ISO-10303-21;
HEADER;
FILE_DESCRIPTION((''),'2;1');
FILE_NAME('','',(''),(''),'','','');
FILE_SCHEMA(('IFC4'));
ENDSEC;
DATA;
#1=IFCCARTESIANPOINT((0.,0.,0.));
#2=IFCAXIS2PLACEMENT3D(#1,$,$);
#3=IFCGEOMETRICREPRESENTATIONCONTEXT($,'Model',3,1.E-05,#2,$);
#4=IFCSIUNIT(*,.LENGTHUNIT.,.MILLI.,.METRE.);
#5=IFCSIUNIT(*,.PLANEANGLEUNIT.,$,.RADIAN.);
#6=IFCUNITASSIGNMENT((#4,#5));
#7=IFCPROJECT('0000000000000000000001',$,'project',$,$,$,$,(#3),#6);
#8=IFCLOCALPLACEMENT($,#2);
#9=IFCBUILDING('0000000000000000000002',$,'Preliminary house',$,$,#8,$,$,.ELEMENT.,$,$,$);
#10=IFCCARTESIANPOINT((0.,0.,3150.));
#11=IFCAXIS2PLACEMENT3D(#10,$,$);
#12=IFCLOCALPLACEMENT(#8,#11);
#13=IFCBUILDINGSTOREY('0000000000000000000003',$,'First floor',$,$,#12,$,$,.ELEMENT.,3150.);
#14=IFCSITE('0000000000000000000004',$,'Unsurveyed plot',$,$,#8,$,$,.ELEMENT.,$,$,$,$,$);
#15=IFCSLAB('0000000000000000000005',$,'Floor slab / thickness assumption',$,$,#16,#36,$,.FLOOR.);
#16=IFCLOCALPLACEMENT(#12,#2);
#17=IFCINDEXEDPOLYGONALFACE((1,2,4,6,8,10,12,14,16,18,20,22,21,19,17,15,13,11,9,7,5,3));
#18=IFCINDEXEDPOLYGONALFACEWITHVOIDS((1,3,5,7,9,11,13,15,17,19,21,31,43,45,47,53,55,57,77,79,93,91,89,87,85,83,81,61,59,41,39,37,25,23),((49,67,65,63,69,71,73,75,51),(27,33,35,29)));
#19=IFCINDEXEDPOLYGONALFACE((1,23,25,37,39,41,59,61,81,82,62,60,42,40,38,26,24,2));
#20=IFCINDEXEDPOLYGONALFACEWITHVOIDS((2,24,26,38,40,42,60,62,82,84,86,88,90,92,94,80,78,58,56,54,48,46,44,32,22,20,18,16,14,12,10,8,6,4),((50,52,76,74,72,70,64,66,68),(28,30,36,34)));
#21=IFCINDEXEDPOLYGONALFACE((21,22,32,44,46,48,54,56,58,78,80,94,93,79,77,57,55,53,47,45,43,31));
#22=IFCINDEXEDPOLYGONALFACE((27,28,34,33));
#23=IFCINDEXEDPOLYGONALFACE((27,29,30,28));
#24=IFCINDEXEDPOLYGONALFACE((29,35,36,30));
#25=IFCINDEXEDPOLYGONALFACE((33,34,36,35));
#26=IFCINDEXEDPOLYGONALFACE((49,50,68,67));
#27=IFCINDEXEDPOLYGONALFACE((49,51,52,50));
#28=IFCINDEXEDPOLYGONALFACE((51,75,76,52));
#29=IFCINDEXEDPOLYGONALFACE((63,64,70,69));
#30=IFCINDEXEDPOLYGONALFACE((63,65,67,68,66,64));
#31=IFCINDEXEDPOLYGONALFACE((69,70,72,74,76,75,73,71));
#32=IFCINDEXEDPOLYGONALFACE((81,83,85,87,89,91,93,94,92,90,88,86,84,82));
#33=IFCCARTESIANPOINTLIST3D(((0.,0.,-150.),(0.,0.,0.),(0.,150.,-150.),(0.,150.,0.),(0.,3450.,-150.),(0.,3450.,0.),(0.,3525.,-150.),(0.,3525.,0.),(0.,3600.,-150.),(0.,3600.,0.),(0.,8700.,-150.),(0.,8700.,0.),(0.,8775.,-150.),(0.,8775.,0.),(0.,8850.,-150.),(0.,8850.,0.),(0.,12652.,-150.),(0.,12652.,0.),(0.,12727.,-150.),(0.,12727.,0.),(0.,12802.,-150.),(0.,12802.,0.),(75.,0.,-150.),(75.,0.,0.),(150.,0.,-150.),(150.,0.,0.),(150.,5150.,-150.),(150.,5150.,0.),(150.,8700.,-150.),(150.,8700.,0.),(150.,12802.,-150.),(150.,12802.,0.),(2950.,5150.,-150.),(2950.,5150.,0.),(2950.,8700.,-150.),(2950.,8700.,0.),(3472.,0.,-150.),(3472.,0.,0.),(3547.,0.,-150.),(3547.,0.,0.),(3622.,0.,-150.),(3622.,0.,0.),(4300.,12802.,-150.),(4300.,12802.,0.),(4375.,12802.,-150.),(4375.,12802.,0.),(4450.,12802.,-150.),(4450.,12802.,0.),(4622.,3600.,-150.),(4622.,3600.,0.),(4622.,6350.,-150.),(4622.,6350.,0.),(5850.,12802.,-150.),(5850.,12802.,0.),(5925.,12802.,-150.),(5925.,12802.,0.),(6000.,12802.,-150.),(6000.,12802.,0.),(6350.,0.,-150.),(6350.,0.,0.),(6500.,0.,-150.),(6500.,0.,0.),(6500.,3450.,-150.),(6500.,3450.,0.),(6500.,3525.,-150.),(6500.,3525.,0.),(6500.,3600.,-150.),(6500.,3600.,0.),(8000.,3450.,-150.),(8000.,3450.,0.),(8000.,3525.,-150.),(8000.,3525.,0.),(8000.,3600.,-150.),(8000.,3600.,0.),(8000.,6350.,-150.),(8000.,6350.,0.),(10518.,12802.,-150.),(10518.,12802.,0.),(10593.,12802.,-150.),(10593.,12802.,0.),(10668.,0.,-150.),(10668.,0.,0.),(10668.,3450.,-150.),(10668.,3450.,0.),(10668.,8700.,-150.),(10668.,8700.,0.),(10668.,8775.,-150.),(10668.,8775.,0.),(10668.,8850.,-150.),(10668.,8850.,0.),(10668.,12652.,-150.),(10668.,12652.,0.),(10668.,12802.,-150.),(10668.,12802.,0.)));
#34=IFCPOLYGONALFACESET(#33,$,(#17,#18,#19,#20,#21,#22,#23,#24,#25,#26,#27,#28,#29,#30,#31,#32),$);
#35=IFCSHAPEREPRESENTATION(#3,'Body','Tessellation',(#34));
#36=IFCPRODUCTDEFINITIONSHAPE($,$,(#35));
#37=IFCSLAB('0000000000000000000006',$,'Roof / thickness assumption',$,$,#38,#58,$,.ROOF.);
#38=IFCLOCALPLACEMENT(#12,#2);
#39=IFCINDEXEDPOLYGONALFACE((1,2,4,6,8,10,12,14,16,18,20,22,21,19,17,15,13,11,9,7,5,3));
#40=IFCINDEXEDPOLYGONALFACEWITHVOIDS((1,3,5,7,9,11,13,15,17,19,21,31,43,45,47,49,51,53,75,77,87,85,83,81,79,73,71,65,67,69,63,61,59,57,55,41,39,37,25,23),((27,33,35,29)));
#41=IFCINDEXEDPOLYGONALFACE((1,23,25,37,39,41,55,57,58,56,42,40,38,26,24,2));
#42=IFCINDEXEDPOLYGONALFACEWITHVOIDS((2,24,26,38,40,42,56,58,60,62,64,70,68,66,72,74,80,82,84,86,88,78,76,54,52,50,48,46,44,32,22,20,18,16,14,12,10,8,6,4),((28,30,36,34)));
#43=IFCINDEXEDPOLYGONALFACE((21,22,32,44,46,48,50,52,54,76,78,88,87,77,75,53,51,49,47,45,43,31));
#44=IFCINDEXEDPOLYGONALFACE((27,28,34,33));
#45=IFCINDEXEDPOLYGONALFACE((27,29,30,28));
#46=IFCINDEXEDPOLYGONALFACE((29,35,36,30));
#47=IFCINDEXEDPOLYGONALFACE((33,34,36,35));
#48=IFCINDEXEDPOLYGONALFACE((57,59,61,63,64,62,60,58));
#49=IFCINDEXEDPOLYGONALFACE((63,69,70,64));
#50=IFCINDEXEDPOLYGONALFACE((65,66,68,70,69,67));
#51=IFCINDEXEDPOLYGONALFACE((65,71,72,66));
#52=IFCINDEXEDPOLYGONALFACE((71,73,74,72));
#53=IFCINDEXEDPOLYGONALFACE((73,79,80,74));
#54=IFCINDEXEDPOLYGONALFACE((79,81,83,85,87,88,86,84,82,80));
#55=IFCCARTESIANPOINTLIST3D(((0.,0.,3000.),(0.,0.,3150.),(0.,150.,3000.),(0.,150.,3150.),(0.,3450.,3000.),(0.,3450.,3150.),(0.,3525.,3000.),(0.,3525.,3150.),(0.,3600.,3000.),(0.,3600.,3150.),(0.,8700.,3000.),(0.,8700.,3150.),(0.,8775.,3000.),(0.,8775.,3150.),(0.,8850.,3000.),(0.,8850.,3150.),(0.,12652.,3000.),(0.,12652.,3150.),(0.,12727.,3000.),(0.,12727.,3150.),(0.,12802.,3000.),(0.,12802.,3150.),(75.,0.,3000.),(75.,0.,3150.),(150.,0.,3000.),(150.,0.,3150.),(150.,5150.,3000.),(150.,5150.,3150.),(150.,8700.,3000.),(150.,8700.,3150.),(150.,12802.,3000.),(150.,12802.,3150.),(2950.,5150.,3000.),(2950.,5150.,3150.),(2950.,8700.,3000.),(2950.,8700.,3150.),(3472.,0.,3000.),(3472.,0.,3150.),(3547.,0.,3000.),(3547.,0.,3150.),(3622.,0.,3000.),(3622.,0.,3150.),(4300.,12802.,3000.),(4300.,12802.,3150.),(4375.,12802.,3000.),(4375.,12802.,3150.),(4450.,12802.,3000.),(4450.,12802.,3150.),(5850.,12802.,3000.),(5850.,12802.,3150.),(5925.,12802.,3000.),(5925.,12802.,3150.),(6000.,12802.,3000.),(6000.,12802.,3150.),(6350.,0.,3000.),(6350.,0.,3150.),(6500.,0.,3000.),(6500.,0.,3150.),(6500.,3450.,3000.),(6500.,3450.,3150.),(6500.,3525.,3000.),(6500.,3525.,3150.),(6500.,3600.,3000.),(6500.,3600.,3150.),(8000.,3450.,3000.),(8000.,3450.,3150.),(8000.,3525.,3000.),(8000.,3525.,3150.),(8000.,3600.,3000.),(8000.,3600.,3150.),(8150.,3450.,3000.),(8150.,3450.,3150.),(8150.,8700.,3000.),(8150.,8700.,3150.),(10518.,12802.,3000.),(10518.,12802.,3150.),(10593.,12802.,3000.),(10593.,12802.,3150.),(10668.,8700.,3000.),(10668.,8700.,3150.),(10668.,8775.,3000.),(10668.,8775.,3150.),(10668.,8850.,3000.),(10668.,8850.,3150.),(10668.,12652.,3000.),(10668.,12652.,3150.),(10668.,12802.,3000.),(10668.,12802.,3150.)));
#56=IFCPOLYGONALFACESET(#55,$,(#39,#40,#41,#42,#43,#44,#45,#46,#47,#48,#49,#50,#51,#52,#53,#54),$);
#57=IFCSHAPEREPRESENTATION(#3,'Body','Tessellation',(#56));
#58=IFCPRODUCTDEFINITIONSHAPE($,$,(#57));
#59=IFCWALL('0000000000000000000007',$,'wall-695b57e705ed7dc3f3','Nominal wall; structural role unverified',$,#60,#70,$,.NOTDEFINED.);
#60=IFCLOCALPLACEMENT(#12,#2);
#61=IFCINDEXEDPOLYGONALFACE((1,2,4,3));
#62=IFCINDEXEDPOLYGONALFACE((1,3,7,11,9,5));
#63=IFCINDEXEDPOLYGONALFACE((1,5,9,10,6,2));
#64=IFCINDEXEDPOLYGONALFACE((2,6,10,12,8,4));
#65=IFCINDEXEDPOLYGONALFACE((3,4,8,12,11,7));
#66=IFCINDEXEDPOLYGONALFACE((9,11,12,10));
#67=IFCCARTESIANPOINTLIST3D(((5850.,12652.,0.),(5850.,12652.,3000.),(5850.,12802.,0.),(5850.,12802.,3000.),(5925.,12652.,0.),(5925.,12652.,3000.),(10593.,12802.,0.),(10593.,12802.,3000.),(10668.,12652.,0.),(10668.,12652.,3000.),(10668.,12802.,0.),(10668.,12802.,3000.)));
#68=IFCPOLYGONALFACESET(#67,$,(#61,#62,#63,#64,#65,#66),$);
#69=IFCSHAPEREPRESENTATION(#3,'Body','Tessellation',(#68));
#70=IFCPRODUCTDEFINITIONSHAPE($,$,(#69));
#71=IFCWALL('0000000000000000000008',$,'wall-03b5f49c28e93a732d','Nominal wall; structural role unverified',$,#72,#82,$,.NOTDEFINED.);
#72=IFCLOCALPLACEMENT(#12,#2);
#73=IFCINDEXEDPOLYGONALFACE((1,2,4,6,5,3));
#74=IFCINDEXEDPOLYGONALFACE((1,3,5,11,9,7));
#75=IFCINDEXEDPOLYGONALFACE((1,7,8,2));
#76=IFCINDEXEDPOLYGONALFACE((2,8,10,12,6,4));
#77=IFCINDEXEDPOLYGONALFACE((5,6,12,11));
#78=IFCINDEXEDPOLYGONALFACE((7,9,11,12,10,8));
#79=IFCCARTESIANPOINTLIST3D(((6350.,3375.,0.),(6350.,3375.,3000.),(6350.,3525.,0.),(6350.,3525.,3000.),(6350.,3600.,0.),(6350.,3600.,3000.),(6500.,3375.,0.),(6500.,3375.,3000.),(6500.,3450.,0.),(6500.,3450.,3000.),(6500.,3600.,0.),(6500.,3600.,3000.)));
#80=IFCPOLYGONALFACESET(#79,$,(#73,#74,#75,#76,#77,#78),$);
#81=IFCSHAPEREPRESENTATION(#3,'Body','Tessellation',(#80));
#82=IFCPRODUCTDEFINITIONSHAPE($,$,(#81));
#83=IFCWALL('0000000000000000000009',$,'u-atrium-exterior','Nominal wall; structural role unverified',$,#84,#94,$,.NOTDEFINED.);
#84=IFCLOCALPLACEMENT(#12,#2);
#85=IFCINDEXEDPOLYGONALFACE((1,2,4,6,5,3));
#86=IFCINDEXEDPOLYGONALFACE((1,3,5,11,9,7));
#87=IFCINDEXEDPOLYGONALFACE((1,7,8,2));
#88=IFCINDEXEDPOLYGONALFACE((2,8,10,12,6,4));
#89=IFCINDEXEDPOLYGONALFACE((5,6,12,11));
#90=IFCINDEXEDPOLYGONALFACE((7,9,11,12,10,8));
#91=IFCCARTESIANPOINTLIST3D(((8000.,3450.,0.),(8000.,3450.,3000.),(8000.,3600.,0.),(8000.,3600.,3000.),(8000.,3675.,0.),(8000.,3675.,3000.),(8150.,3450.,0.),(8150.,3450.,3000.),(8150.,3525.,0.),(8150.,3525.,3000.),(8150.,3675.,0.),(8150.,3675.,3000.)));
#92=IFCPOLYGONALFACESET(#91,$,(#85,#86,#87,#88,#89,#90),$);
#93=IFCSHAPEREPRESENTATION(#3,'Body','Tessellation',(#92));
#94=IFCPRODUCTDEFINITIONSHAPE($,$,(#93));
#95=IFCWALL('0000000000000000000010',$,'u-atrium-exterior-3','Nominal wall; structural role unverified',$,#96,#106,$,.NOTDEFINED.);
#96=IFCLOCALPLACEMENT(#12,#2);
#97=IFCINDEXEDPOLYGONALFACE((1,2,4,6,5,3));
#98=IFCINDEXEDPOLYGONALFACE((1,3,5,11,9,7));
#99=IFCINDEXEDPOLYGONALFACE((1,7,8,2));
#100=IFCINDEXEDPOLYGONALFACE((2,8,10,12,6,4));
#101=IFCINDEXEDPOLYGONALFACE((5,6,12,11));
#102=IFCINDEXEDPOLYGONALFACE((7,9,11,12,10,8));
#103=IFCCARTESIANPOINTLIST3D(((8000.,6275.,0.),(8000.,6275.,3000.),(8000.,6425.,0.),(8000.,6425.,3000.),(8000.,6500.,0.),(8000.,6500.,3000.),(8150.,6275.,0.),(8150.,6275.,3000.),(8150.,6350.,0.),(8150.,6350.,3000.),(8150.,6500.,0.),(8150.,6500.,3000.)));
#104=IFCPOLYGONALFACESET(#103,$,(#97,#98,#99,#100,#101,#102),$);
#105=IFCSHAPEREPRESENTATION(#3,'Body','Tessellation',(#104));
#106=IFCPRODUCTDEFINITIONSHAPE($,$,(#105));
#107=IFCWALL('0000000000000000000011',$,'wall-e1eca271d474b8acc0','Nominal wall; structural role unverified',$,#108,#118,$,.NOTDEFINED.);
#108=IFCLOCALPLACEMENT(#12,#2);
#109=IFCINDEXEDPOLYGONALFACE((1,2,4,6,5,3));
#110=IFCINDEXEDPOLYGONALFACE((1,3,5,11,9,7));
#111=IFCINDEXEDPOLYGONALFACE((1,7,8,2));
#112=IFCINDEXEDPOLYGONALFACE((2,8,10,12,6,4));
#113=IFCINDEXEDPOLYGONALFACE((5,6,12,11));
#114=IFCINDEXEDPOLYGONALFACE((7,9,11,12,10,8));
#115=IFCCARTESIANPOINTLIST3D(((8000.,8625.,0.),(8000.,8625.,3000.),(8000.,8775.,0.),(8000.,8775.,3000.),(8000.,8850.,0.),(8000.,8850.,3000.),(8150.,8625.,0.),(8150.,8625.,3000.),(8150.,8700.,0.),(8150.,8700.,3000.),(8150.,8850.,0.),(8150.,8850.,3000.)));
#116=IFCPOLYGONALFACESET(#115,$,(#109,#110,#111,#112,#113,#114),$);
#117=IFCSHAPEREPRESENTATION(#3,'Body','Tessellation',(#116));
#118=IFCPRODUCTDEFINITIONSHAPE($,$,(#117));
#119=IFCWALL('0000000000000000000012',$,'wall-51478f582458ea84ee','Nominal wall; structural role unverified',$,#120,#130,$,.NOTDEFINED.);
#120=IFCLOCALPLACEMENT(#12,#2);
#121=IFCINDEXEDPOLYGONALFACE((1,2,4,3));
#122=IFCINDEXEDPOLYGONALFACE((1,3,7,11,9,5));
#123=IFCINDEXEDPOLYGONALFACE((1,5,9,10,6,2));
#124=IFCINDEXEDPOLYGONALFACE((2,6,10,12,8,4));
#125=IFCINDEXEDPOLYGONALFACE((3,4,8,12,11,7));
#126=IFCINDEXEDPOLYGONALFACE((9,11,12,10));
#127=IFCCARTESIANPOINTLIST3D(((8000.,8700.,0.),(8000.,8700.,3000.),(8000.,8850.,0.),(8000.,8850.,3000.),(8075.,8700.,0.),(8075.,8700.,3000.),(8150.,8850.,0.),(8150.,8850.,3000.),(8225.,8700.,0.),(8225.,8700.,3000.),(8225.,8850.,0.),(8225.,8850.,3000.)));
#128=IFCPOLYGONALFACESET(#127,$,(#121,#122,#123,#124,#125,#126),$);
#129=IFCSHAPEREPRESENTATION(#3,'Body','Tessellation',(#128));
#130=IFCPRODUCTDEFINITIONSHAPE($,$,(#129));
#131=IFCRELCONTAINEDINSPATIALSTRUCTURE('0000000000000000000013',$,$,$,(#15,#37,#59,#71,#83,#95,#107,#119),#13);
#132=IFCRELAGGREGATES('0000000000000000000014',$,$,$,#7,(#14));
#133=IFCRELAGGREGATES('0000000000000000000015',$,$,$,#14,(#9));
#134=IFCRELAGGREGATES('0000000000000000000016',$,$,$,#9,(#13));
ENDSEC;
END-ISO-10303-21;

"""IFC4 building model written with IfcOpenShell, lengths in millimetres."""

from ifc_helpers import new_model, si_unit, frame, origin, place, context, project, spatial, polyline, outline, extrude, element, save


model = new_model("IFC4")

# Units and contexts
model_context = context("Model", 3, precision=1e-05, world=origin())
ifc_project = project(units=[si_unit("LENGTHUNIT", "METRE", prefix="MILLI"), si_unit("PLANEANGLEUNIT", "RADIAN")], contexts=[model_context])

# Site, building, storey
placement_1 = place(None, origin())
site = spatial("IfcSite", under=ifc_project, at=placement_1, Name="Unsurveyed plot", CompositionType="ELEMENT")
building = spatial("IfcBuilding", under=site, at=placement_1, Name="Preliminary house", CompositionType="ELEMENT")
placement_2 = place(placement_1, frame((0.0, 0.0, 3150.0)))
storey = spatial("IfcBuildingStorey", under=building, at=placement_2, Name="First floor", CompositionType="ELEMENT", Elevation=3150.0)

# Slabs
element("IfcSlab", 1, at=placement_2, inside=storey, Name="Floor slab / thickness assumption", PredefinedType="FLOOR", context=model_context, shape_type="SweptSolid", body=[
    extrude(outline(polyline([(75.0, 0.0), (0.0, 0.0), (0.0, 150.0), (0.0, 3450.0), (0.0, 3525.0), (0.0, 3600.0), (0.0, 8700.0), (0.0, 8775.0), (0.0, 8850.0), (0.0, 12652.0), (0.0, 12727.0), (0.0, 12802.0), (150.0, 12802.0), (4300.0, 12802.0), (4375.0, 12802.0), (4450.0, 12802.0), (5850.0, 12802.0), (5925.0, 12802.0), (6000.0, 12802.0), (10518.0, 12802.0), (10593.0, 12802.0), (10668.0, 12802.0), (10668.0, 12652.0), (10668.0, 8850.0), (10668.0, 8775.0), (10668.0, 8700.0), (10668.0, 3450.0), (10668.0, 0.0), (6500.0, 0.0), (6350.0, 0.0), (3622.0, 0.0), (3547.0, 0.0), (3472.0, 0.0), (150.0, 0.0), (75.0, 0.0)]), holes=[polyline([(8000.0, 3450.0), (8000.0, 3525.0), (8000.0, 3600.0), (8000.0, 6350.0), (4622.0, 6350.0), (4622.0, 3600.0), (6500.0, 3600.0), (6500.0, 3525.0), (6500.0, 3450.0), (8000.0, 3450.0)]), polyline([(2950.0, 8700.0), (150.0, 8700.0), (150.0, 5150.0), (2950.0, 5150.0), (2950.0, 8700.0)])]), frame((0.0, 0.0, -150.0)), (0.0, 0.0, 1.0), 150.0),
])
element("IfcSlab", 2, at=placement_2, inside=storey, Name="Roof / thickness assumption", PredefinedType="ROOF", context=model_context, shape_type="SweptSolid", body=[
    extrude(outline(polyline([(0.0, 0.0), (0.0, 150.0), (0.0, 3450.0), (0.0, 3525.0), (0.0, 3600.0), (0.0, 8700.0), (0.0, 8775.0), (0.0, 8850.0), (0.0, 12652.0), (0.0, 12727.0), (0.0, 12802.0), (150.0, 12802.0), (4300.0, 12802.0), (4375.0, 12802.0), (4450.0, 12802.0), (5850.0, 12802.0), (5925.0, 12802.0), (6000.0, 12802.0), (10518.0, 12802.0), (10593.0, 12802.0), (10668.0, 12802.0), (10668.0, 12652.0), (10668.0, 8850.0), (10668.0, 8775.0), (10668.0, 8700.0), (8150.0, 8700.0), (8150.0, 3450.0), (8000.0, 3450.0), (8000.0, 3525.0), (8000.0, 3600.0), (6500.0, 3600.0), (6500.0, 3525.0), (6500.0, 3450.0), (6500.0, 0.0), (6350.0, 0.0), (3622.0, 0.0), (3547.0, 0.0), (3472.0, 0.0), (150.0, 0.0), (75.0, 0.0), (0.0, 0.0)]), holes=[polyline([(2950.0, 8700.0), (150.0, 8700.0), (150.0, 5150.0), (2950.0, 5150.0), (2950.0, 8700.0)])]), frame((0.0, 0.0, 3000.0)), (0.0, 0.0, 1.0), 150.0),
])

# Wall
element("IfcWall", 3, at=placement_2, inside=storey, Name="wall-695b57e705ed7dc3f3", Description="Nominal wall; structural role unverified", PredefinedType="NOTDEFINED", context=model_context, shape_type="SweptSolid", body=[
    extrude(outline(polyline([(10593.0, 12802.0), (10668.0, 12802.0), (10668.0, 12652.0), (5925.0, 12652.0), (5850.0, 12652.0), (5850.0, 12802.0), (10593.0, 12802.0)])), origin(), (0.0, 0.0, 1.0), 3000.0),
])

# Walls
element("IfcWall", 4, at=placement_2, inside=storey, Name="wall-03b5f49c28e93a732d", Description="Nominal wall; structural role unverified", PredefinedType="NOTDEFINED", context=model_context, shape_type="SweptSolid", body=[
    extrude(outline(polyline([(6350.0, 3525.0), (6350.0, 3600.0), (6500.0, 3600.0), (6500.0, 3450.0), (6500.0, 3375.0), (6350.0, 3375.0), (6350.0, 3525.0)])), origin(), (0.0, 0.0, 1.0), 3000.0),
])
element("IfcWall", 5, at=placement_2, inside=storey, Name="u-atrium-exterior", Description="Nominal wall; structural role unverified", PredefinedType="NOTDEFINED", context=model_context, shape_type="SweptSolid", body=[
    extrude(outline(polyline([(8000.0, 3600.0), (8000.0, 3675.0), (8150.0, 3675.0), (8150.0, 3525.0), (8150.0, 3450.0), (8000.0, 3450.0), (8000.0, 3600.0)])), origin(), (0.0, 0.0, 1.0), 3000.0),
])

# Wall
element("IfcWall", 6, at=placement_2, inside=storey, Name="u-atrium-exterior-3", Description="Nominal wall; structural role unverified", PredefinedType="NOTDEFINED", context=model_context, shape_type="SweptSolid", body=[
    extrude(outline(polyline([(8000.0, 6425.0), (8000.0, 6500.0), (8150.0, 6500.0), (8150.0, 6350.0), (8150.0, 6275.0), (8000.0, 6275.0), (8000.0, 6425.0)])), origin(), (0.0, 0.0, 1.0), 3000.0),
])

# Walls
element("IfcWall", 7, at=placement_2, inside=storey, Name="wall-e1eca271d474b8acc0", Description="Nominal wall; structural role unverified", PredefinedType="NOTDEFINED", context=model_context, shape_type="SweptSolid", body=[
    extrude(outline(polyline([(8000.0, 8775.0), (8000.0, 8850.0), (8150.0, 8850.0), (8150.0, 8700.0), (8150.0, 8625.0), (8000.0, 8625.0), (8000.0, 8775.0)])), origin(), (0.0, 0.0, 1.0), 3000.0),
])
element("IfcWall", 8, at=placement_2, inside=storey, Name="wall-51478f582458ea84ee", Description="Nominal wall; structural role unverified", PredefinedType="NOTDEFINED", context=model_context, shape_type="SweptSolid", body=[
    extrude(outline(polyline([(8150.0, 8850.0), (8225.0, 8850.0), (8225.0, 8700.0), (8075.0, 8700.0), (8000.0, 8700.0), (8000.0, 8850.0), (8150.0, 8850.0)])), origin(), (0.0, 0.0, 1.0), 3000.0),
])

save(model, "model.ifc")
